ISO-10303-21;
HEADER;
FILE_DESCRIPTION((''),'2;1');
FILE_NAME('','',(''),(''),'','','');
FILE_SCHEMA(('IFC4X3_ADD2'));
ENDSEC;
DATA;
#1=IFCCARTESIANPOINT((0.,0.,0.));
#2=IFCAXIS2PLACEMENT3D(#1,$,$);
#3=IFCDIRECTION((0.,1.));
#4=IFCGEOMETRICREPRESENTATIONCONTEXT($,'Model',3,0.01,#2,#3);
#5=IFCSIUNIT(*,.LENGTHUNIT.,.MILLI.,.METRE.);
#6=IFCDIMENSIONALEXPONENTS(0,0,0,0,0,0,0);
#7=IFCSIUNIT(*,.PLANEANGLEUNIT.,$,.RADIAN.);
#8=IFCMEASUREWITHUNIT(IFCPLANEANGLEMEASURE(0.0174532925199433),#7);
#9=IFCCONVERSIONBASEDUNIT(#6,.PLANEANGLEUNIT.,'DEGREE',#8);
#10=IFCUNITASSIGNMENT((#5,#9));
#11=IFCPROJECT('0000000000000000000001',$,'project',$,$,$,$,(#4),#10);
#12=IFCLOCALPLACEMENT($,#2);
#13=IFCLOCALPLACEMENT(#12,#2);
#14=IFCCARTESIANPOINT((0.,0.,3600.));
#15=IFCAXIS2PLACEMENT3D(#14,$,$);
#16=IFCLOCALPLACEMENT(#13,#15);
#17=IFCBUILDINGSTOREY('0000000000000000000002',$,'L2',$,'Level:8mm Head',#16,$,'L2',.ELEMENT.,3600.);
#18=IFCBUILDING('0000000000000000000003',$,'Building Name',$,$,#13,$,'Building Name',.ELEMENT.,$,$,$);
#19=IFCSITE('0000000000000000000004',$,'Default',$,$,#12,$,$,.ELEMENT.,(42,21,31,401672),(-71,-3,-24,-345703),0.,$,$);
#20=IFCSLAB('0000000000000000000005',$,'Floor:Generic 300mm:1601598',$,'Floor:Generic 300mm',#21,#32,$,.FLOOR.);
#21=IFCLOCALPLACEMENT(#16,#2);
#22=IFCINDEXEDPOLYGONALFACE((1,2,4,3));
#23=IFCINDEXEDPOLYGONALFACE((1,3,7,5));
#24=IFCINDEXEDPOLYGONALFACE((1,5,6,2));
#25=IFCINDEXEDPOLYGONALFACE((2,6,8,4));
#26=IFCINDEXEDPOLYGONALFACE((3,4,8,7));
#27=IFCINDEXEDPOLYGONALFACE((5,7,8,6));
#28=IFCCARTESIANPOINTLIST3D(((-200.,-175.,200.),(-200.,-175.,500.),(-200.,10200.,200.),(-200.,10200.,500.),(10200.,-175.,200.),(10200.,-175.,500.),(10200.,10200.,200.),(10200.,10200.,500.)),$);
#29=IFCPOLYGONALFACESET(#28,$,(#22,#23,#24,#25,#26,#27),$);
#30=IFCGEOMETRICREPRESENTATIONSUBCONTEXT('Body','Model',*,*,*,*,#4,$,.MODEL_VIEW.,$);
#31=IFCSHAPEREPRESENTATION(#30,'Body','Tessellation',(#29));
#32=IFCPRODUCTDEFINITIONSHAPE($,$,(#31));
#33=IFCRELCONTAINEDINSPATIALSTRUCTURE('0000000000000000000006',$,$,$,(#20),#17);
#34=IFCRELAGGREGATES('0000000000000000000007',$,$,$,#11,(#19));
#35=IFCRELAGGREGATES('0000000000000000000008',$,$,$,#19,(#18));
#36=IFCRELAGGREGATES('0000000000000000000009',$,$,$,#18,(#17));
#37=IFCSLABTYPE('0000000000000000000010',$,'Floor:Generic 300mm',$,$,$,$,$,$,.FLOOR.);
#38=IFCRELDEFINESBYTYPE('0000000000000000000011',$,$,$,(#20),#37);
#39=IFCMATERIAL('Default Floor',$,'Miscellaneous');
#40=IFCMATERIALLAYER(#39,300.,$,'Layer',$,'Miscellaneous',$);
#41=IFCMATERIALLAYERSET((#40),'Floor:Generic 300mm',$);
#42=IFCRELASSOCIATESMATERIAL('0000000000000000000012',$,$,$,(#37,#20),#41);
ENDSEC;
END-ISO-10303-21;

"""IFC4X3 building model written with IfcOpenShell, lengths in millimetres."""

from ifc_helpers import new_model, entity, si_unit, converted_unit, direction, frame, frame_2d, origin, place, context, subcontext, project, spatial, rectangle, extrude, material, layer, layer_set, layer_usage, type_object, element, save


model = new_model("IFC4X3")

# Units and contexts
model_context = context("Model", 3, precision=0.01, world=origin(), true_north=direction((0.0, 1.0)))
body_context = subcontext(model_context, "Body", "Model", "MODEL_VIEW")
ifc_project = project(units=[si_unit("LENGTHUNIT", "METRE", prefix="MILLI"), converted_unit("PLANEANGLEUNIT", "DEGREE", entity("IfcPlaneAngleMeasure", 0.0174532925199433), si_unit("PLANEANGLEUNIT", "RADIAN"), dimensions=[0, 0, 0, 0, 0, 0, 0])], contexts=[model_context])

# Site, building, storey
site_placement = place(None, origin())
site = spatial("IfcSite", under=ifc_project, at=site_placement, Name="Default", CompositionType="ELEMENT", RefLatitude=(42, 21, 31, 401672), RefLongitude=(-71, -3, -24, -345703), RefElevation=0.0)
building_placement = place(site_placement, origin())
building = spatial("IfcBuilding", under=site, at=building_placement, Name="Building Name", LongName="Building Name", CompositionType="ELEMENT")
storey_placement = place(building_placement, frame((0.0, 0.0, 3600.0)))
storey = spatial("IfcBuildingStorey", under=building, at=storey_placement, Name="L2", ObjectType="Level:8mm Head", LongName="L2", CompositionType="ELEMENT", Elevation=3600.0)

# Slab
ifc_material = material(Name="Default Floor", Category="Miscellaneous")
ifc_layer = layer(ifc_material, 300.0, Name="Layer", Category="Miscellaneous")
ifc_layer_set = layer_set([ifc_layer], Name="Floor:Generic 300mm")
ifc_layer_usage = layer_usage(ifc_layer_set, "AXIS3", "POSITIVE", 0.0)
slab_type = type_object("IfcSlabType", Name="Floor:Generic 300mm", PredefinedType="FLOOR", material=ifc_layer_set)
slab_placement = place(storey_placement, origin())
element("IfcSlab", 1, at=slab_placement, inside=storey, type_object=slab_type, material=ifc_layer_usage, Name="Floor:Generic 300mm:1601598", ObjectType="Floor:Generic 300mm", PredefinedType="FLOOR", context=body_context, shape_type="SweptSolid", body=[
    extrude(rectangle(XDim=10375.0, YDim=10400.0, at=frame_2d((0.0, 0.0), x_axis=(1.0, 0.0))), frame((5000.0, 5012.5, 500.0), z_axis=(0.0, 0.0, -1.0), x_axis=(0.0, 1.0, 0.0)), (0.0, 0.0, 1.0), 300.0),
])

save(model, "model.ifc")
